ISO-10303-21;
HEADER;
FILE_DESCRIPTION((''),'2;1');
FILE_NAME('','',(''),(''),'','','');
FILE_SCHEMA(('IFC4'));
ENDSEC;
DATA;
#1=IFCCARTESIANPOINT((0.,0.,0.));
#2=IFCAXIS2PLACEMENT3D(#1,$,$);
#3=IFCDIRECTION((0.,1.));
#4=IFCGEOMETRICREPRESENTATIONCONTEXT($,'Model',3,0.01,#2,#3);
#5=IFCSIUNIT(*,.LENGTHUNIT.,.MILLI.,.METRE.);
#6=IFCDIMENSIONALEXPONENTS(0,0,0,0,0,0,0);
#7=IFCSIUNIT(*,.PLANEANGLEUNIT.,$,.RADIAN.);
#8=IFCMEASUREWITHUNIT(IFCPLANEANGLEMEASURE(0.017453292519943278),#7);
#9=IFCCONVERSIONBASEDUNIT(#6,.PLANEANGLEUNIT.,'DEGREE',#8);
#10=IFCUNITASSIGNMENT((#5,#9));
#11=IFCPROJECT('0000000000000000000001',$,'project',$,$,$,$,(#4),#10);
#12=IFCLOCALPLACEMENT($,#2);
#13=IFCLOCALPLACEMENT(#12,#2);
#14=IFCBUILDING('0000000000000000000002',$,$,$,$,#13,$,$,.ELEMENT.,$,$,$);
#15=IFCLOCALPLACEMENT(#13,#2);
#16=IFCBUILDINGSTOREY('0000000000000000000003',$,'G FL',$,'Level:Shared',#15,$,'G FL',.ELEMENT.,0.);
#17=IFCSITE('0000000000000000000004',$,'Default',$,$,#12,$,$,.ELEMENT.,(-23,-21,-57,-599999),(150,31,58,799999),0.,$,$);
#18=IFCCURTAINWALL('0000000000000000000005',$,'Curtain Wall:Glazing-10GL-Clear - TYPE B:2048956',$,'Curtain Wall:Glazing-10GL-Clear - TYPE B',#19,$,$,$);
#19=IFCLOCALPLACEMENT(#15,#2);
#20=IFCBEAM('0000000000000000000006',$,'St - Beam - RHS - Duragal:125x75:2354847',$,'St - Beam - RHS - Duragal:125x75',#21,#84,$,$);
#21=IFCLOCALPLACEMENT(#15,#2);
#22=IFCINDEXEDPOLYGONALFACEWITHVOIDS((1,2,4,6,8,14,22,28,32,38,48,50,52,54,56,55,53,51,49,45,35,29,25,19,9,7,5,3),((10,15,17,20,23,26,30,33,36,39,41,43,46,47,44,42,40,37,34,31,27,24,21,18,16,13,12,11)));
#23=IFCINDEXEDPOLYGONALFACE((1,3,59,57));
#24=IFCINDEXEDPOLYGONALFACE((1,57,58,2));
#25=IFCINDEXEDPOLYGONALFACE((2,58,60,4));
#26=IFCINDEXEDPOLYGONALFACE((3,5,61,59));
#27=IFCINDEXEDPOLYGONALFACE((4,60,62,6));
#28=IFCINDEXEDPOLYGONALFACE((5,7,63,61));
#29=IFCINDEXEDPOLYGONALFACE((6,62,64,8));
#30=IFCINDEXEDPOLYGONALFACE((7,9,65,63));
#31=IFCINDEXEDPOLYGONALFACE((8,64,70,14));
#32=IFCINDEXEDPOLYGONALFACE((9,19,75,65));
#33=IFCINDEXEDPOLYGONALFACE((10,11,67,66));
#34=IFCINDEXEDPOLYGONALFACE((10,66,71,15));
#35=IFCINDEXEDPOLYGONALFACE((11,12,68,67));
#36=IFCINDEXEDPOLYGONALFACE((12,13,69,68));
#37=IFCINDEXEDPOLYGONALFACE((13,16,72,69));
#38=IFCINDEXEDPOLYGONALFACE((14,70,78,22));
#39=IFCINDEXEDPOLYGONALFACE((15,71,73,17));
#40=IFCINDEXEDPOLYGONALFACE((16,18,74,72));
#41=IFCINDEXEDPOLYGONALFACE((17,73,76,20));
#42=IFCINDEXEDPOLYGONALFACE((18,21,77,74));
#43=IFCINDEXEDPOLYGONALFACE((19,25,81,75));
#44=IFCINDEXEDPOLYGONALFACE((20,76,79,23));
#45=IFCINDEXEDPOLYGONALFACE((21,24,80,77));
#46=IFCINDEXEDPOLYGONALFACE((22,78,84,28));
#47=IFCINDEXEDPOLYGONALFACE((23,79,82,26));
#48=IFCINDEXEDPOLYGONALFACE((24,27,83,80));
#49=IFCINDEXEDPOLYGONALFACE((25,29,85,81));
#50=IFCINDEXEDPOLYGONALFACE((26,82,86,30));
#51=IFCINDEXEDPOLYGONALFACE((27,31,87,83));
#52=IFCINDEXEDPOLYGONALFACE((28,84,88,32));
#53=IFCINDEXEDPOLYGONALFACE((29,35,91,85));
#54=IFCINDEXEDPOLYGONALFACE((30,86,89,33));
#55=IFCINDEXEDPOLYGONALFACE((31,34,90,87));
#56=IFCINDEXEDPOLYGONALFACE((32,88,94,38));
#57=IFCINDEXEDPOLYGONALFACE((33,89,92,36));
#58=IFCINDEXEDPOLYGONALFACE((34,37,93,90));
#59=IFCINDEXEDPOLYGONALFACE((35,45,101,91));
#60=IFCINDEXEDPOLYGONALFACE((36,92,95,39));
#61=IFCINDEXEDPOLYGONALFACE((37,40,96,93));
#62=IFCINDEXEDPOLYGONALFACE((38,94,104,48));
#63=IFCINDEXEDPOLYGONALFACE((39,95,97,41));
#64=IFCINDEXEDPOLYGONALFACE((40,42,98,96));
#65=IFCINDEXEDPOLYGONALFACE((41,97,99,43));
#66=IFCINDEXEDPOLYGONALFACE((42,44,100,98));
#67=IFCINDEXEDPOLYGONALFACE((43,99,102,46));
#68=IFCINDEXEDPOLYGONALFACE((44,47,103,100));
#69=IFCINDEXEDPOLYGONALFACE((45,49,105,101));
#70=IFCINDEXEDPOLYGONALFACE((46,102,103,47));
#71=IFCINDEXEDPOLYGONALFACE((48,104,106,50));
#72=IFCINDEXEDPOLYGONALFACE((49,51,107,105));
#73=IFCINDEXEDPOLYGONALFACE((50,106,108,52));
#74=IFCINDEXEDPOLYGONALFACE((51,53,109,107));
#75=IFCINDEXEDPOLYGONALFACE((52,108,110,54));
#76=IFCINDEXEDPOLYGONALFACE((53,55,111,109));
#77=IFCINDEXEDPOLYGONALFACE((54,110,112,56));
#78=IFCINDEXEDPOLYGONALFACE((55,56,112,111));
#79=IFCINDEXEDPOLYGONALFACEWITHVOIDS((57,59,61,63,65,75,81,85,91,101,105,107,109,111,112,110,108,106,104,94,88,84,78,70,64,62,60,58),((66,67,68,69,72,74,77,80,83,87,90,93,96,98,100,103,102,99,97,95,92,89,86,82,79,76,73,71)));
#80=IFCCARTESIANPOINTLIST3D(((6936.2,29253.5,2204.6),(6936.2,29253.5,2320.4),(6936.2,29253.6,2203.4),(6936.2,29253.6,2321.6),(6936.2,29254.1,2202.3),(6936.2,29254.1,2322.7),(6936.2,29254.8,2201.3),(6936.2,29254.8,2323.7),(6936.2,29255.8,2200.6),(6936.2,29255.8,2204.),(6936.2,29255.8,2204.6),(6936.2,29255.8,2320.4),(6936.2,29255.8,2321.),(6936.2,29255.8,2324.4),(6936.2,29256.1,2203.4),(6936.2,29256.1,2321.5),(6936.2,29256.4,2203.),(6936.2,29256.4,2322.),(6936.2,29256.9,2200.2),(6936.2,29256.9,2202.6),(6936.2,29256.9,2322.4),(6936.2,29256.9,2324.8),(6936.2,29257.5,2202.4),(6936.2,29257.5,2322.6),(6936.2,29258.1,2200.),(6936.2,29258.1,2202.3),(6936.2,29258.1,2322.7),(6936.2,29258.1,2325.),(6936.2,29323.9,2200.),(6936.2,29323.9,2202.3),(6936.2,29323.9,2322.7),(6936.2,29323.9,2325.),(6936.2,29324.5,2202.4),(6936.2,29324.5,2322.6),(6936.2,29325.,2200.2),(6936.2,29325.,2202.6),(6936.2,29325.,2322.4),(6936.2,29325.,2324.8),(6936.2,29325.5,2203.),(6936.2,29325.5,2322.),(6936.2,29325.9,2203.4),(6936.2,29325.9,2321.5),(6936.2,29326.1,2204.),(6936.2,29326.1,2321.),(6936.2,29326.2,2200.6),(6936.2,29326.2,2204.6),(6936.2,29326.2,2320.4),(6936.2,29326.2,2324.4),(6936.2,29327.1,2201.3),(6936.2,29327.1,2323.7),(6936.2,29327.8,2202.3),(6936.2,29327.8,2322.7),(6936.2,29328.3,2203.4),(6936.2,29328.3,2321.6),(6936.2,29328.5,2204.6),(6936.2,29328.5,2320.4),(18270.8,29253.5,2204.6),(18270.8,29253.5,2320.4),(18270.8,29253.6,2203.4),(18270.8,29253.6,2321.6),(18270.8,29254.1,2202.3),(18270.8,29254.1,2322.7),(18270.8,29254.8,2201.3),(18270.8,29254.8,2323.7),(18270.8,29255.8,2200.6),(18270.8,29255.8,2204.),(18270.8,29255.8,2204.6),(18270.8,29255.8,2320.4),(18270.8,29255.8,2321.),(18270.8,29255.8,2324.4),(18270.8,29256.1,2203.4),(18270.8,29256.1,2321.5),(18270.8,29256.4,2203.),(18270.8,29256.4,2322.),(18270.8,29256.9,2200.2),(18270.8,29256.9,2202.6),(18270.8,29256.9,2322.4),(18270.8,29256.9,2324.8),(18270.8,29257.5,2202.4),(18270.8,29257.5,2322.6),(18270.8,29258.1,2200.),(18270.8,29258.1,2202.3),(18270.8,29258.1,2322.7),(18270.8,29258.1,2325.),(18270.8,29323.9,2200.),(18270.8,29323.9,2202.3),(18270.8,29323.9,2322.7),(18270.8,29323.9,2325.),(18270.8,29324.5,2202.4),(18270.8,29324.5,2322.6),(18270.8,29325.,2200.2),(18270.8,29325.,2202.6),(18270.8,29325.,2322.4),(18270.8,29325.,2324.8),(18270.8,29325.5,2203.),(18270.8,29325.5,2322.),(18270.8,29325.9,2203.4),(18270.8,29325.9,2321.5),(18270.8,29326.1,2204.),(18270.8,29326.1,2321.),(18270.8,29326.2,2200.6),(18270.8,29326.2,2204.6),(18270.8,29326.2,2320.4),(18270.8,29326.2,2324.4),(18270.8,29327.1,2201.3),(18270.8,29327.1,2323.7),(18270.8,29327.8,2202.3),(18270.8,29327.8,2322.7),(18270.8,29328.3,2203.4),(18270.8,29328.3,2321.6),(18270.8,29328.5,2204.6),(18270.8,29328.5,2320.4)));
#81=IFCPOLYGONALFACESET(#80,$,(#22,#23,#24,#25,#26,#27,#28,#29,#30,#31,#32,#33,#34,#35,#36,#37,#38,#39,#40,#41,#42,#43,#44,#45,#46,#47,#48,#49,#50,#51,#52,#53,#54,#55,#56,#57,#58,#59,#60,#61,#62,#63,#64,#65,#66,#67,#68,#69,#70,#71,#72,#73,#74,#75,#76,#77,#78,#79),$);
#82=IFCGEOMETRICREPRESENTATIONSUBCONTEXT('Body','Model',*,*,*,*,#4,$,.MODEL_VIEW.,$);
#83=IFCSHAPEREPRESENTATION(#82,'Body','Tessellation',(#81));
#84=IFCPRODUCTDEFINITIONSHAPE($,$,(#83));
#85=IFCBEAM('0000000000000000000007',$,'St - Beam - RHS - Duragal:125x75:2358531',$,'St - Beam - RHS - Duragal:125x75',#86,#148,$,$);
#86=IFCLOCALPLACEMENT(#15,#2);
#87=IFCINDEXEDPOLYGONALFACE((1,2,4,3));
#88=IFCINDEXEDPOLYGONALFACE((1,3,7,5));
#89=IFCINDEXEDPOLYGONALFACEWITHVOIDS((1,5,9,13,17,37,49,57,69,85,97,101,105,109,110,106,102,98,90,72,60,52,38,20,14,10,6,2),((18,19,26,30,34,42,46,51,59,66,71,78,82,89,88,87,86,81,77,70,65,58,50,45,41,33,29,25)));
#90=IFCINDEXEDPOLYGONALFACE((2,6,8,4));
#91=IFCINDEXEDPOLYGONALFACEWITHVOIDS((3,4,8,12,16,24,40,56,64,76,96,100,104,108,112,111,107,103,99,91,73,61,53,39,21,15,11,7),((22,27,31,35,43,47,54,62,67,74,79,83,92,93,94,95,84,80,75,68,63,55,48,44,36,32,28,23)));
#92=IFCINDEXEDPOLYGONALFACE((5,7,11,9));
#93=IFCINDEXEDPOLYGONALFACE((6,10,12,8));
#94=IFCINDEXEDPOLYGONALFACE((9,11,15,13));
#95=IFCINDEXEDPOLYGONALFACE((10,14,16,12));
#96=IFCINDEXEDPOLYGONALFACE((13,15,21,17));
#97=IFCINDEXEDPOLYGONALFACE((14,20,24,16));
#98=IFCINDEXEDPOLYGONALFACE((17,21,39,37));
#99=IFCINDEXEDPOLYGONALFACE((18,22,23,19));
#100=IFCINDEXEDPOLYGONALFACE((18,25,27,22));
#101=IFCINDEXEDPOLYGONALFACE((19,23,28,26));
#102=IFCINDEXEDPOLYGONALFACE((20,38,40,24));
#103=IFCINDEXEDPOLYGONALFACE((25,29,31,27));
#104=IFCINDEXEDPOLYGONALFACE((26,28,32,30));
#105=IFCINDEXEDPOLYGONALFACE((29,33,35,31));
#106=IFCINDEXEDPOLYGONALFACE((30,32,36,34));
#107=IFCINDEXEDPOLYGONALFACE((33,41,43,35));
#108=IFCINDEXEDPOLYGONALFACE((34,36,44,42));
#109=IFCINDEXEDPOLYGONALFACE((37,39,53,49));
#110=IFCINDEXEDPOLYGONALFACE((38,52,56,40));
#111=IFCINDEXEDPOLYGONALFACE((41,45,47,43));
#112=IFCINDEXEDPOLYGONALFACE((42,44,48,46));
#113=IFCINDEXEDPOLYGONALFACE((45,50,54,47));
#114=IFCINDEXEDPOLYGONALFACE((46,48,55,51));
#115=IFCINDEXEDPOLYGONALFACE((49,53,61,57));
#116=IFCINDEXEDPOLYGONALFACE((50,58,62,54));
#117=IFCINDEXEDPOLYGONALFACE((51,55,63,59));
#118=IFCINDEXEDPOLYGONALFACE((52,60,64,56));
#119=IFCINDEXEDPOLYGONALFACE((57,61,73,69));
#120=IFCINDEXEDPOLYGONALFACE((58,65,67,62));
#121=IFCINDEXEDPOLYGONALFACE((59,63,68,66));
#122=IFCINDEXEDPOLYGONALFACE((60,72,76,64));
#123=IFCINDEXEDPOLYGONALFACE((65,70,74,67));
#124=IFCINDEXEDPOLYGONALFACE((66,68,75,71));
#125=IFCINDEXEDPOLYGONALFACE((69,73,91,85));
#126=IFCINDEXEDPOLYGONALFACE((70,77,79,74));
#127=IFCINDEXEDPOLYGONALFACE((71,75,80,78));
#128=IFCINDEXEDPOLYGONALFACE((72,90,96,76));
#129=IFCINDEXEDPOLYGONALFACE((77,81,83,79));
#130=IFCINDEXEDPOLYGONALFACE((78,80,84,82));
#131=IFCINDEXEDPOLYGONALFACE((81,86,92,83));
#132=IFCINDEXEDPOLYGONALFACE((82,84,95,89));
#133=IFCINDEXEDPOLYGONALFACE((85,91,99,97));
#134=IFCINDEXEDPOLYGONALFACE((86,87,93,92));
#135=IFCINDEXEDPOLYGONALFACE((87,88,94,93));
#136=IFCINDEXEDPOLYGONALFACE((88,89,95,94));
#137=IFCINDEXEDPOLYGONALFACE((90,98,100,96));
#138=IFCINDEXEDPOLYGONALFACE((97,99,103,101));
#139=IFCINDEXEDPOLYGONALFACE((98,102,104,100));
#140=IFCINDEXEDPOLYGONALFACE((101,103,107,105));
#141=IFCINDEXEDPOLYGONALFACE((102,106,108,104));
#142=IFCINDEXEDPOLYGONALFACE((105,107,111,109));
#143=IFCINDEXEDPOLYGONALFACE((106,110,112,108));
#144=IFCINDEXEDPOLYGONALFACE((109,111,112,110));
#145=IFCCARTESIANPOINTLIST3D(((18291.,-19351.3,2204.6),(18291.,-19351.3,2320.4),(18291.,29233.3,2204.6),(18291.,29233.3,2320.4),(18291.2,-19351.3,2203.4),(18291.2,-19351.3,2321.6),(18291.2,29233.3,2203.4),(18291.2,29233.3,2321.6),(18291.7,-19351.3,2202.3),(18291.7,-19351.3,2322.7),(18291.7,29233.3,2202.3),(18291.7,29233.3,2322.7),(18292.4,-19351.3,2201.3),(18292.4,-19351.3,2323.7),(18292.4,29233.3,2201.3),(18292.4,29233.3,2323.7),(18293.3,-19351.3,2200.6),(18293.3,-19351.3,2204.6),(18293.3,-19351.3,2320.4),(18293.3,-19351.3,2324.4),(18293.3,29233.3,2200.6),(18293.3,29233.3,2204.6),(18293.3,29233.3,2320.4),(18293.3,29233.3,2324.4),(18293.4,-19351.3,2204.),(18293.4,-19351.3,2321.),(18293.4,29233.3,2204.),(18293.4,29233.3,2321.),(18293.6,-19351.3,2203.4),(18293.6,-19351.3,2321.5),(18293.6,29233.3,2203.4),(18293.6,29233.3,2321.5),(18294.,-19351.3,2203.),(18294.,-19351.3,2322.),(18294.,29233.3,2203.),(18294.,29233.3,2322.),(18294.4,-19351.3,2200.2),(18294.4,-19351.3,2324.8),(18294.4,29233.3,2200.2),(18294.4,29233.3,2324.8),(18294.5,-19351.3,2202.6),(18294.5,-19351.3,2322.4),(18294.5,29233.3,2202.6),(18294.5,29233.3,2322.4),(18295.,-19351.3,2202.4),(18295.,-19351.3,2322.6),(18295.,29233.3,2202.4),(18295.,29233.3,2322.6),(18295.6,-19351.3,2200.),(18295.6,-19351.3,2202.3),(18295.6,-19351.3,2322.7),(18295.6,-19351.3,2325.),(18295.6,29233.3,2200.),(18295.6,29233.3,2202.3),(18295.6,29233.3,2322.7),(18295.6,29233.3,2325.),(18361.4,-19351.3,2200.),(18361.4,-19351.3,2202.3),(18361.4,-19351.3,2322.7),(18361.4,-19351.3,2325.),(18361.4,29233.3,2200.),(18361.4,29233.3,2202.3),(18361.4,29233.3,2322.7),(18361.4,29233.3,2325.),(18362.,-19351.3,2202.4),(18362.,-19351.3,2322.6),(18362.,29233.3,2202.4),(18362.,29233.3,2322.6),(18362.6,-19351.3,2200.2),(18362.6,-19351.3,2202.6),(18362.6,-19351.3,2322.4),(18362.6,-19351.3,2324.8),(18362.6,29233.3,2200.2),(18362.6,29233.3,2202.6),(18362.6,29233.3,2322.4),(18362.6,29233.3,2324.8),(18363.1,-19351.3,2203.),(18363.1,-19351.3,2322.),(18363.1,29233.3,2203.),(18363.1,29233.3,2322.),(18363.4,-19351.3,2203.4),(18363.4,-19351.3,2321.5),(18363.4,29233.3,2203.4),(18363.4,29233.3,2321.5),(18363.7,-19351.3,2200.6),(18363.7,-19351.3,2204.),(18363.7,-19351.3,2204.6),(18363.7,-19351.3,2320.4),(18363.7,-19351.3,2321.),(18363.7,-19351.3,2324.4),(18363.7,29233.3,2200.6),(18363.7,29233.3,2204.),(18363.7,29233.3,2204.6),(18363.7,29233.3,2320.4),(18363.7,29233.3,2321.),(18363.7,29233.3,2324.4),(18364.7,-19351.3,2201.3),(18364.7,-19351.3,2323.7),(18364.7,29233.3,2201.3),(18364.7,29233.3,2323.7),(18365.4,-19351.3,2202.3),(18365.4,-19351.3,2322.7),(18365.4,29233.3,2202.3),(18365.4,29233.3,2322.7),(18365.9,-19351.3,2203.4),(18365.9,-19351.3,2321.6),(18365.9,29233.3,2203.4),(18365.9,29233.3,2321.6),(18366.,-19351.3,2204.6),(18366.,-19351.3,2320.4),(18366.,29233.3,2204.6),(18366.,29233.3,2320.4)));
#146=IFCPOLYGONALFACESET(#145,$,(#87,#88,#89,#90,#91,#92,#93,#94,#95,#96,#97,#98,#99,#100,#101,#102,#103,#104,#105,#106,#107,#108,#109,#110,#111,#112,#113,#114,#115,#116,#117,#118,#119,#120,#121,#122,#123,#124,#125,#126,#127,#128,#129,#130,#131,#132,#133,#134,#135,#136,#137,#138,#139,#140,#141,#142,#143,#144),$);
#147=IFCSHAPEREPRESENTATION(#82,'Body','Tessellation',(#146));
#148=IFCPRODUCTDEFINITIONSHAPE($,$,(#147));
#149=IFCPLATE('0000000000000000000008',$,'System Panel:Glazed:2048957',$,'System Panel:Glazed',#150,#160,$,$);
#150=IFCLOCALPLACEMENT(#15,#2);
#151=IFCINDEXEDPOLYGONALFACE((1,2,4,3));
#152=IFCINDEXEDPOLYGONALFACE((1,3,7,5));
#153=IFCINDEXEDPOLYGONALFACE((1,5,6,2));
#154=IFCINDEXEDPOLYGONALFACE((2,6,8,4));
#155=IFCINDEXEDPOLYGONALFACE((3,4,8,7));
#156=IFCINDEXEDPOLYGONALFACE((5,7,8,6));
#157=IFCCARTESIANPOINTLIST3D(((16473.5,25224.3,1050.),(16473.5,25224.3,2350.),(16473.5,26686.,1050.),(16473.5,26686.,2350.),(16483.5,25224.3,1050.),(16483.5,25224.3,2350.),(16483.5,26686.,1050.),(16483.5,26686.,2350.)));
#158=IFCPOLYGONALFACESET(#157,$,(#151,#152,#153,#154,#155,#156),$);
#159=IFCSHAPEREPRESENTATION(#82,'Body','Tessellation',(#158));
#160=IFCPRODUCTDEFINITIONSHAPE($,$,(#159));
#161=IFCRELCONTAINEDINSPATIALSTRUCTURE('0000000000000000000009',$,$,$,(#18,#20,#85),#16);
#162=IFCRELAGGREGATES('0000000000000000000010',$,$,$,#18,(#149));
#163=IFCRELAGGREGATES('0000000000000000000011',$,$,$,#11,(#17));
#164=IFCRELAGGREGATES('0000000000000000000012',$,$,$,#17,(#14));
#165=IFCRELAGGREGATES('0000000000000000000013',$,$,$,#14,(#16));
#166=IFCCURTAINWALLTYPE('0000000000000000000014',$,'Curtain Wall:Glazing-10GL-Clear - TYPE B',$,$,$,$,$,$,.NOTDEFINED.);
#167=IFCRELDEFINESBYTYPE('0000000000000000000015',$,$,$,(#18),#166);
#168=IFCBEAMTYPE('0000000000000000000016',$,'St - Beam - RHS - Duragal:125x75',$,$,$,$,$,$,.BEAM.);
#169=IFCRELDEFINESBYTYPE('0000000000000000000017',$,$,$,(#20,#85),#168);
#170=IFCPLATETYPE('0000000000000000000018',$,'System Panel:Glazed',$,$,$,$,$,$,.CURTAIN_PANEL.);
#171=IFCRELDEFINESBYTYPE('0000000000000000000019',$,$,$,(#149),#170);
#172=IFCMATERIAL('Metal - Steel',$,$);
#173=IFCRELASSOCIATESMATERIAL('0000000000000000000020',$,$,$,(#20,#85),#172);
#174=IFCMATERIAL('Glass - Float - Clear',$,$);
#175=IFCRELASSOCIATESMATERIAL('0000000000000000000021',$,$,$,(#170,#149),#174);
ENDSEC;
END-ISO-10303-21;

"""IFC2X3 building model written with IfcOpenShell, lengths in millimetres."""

from ifc_helpers import new_model, entity, si_unit, converted_unit, direction, frame, frame_2d, origin, origin_2d_with_axis, place, context, subcontext, project, spatial, polyline, circle_curve, parameter, trimmed, segment, composite_curve, rectangle, outline, extrude, source, transform, mapped, material, type_object, type_shapes, element, aggregate, save


model = new_model("IFC2X3")

# Units and contexts
model_context = context("Model", 3, precision=0.01, world=origin(), true_north=direction((0.0, 1.0)))
body_context = subcontext(model_context, "Body", "Model", "MODEL_VIEW")
ifc_project = project(units=[si_unit("LENGTHUNIT", "METRE", prefix="MILLI"), converted_unit("PLANEANGLEUNIT", "DEGREE", entity("IfcPlaneAngleMeasure", 0.017453292519943278), si_unit("PLANEANGLEUNIT", "RADIAN"), dimensions=[0, 0, 0, 0, 0, 0, 0])], contexts=[model_context])

# Site, building, storey
site_placement = place(None, origin())
site = spatial("IfcSite", under=ifc_project, at=site_placement, Name="Default", CompositionType="ELEMENT", RefLatitude=(-23, -21, -57, -599999), RefLongitude=(150, 31, 58, 799999), RefElevation=0.0)
building_placement = place(site_placement, origin())
building = spatial("IfcBuilding", under=site, at=building_placement, CompositionType="ELEMENT")
storey_placement = place(building_placement, origin())
storey = spatial("IfcBuildingStorey", under=building, at=storey_placement, Name="G FL", ObjectType="Level:Shared", LongName="G FL", CompositionType="ELEMENT", Elevation=0.0)

# Shared definitions
curtain_wall_type = type_object("IfcCurtainWallType", Name="Curtain Wall:Glazing-10GL-Clear - TYPE B", PredefinedType="NOTDEFINED")

# Curtain wall
curtain_wall_1_placement = place(storey_placement, origin())
curtain_wall_1 = element("IfcCurtainWall", 1, at=curtain_wall_1_placement, inside=storey, type_object=curtain_wall_type, Name="Curtain Wall:Glazing-10GL-Clear - TYPE B:2048956", ObjectType="Curtain Wall:Glazing-10GL-Clear - TYPE B")

# Beams
ifc_material_1 = material(Name="Metal - Steel")
beam_type_1 = type_object("IfcBeamType", Name="St - Beam - RHS - Duragal:125x75", PredefinedType="BEAM")
beam_1_placement = place(storey_placement, frame((18328.5, 29291.0, 2325.0), z_axis=(0.0, 0.0, 1.0), x_axis=(-1.0, 0.0, 0.0)))
element("IfcBeam", 2, at=beam_1_placement, inside=storey, type_object=beam_type_1, material=ifc_material_1, Name="St - Beam - RHS - Duragal:125x75:2354847", ObjectType="St - Beam - RHS - Duragal:125x75", context=body_context, shape_type="SweptSolid", body=[
    extrude(outline(composite_curve([segment(polyline([(-32.9, -62.5), (32.9, -62.5)]), True, "CONTINUOUS"), segment(trimmed(circle_curve(frame_2d((32.9, -57.9), x_axis=(1.0, 0.0)), 4.6), [parameter(270.0)], [parameter(0.0)], True, "PARAMETER"), True, "CONTINUOUS"), segment(polyline([(37.5, -57.9), (37.5, 57.9)]), True, "CONTINUOUS"), segment(trimmed(circle_curve(frame_2d((32.9, 57.9), x_axis=(1.0, 0.0)), 4.6), [parameter(0.0)], [parameter(90.0)], True, "PARAMETER"), True, "CONTINUOUS"), segment(polyline([(32.9, 62.5), (-32.9, 62.5)]), True, "CONTINUOUS"), segment(trimmed(circle_curve(frame_2d((-32.9, 57.9), x_axis=(1.0, 0.0)), 4.6), [parameter(90.0)], [parameter(180.0)], True, "PARAMETER"), True, "CONTINUOUS"), segment(polyline([(-37.5, 57.9), (-37.5, -57.9)]), True, "CONTINUOUS"), segment(trimmed(circle_curve(frame_2d((-32.9, -57.9), x_axis=(1.0, 0.0)), 4.6), [parameter(180.0)], [parameter(270.0)], True, "PARAMETER"), True, "CONTINUOUS")], self_intersect=False), holes=[composite_curve([segment(polyline([(35.2, 57.9), (35.2, -57.9)]), True, "CONTINUOUS"), segment(trimmed(circle_curve(frame_2d((32.9, -57.9), x_axis=(1.0, 0.0)), 2.3), [parameter(270.0)], [parameter(0.0)], True, "PARAMETER"), False, "CONTINUOUS"), segment(polyline([(32.9, -60.2), (-32.9, -60.2)]), True, "CONTINUOUS"), segment(trimmed(circle_curve(frame_2d((-32.9, -57.9), x_axis=(1.0, 0.0)), 2.3), [parameter(180.0)], [parameter(270.0)], True, "PARAMETER"), False, "CONTINUOUS"), segment(polyline([(-35.2, -57.9), (-35.2, 57.9)]), True, "CONTINUOUS"), segment(trimmed(circle_curve(frame_2d((-32.9, 57.9), x_axis=(1.0, 0.0)), 2.3), [parameter(90.0)], [parameter(180.0)], True, "PARAMETER"), False, "CONTINUOUS"), segment(polyline([(-32.9, 60.2), (32.9, 60.2)]), True, "CONTINUOUS"), segment(trimmed(circle_curve(frame_2d((32.9, 57.9), x_axis=(1.0, 0.0)), 2.3), [parameter(0.0)], [parameter(90.0)], True, "PARAMETER"), False, "CONTINUOUS")], self_intersect=False)]), frame((57.7, 0.0, -62.5), z_axis=(1.0, 0.0, 0.0), x_axis=(0.0, -1.0, 0.0)), (0.0, 0.0, 1.0), 11334.6),
])
beam_2_placement = place(storey_placement, frame((18328.5, 29291.0, 2325.0), z_axis=(0.0, 0.0, 1.0), x_axis=(0.0, -1.0, 0.0)))
element("IfcBeam", 3, at=beam_2_placement, inside=storey, type_object=beam_type_1, material=ifc_material_1, Name="St - Beam - RHS - Duragal:125x75:2358531", ObjectType="St - Beam - RHS - Duragal:125x75", context=body_context, shape_type="SweptSolid", body=[
    extrude(outline(composite_curve([segment(trimmed(circle_curve(frame_2d((-32.9, 57.9), x_axis=(1.0, 0.0)), 4.6), [parameter(90.0)], [parameter(180.0)], True, "PARAMETER"), True, "CONTINUOUS"), segment(polyline([(-37.5, 57.9), (-37.5, -57.9)]), True, "CONTINUOUS"), segment(trimmed(circle_curve(frame_2d((-32.9, -57.9), x_axis=(1.0, 0.0)), 4.6), [parameter(180.0)], [parameter(270.0)], True, "PARAMETER"), True, "CONTINUOUS"), segment(polyline([(-32.9, -62.5), (32.9, -62.5)]), True, "CONTINUOUS"), segment(trimmed(circle_curve(frame_2d((32.9, -57.9), x_axis=(1.0, 0.0)), 4.6), [parameter(270.0)], [parameter(360.0)], True, "PARAMETER"), True, "CONTINUOUS"), segment(polyline([(37.5, -57.9), (37.5, 57.9)]), True, "CONTINUOUS"), segment(trimmed(circle_curve(frame_2d((32.9, 57.9), x_axis=(1.0, 0.0)), 4.6), [parameter(0.0)], [parameter(90.0)], True, "PARAMETER"), True, "CONTINUOUS"), segment(polyline([(32.9, 62.5), (-32.9, 62.5)]), True, "CONTINUOUS")], self_intersect=False), holes=[composite_curve([segment(trimmed(circle_curve(frame_2d((32.9, -57.9), x_axis=(1.0, 0.0)), 2.3), [parameter(270.0)], [parameter(360.0)], True, "PARAMETER"), False, "CONTINUOUS"), segment(polyline([(32.9, -60.2), (-32.9, -60.2)]), True, "CONTINUOUS"), segment(trimmed(circle_curve(frame_2d((-32.9, -57.9), x_axis=(1.0, 0.0)), 2.3), [parameter(180.0)], [parameter(270.0)], True, "PARAMETER"), False, "CONTINUOUS"), segment(polyline([(-35.2, -57.9), (-35.2, 57.9)]), True, "CONTINUOUS"), segment(trimmed(circle_curve(frame_2d((-32.9, 57.9), x_axis=(1.0, 0.0)), 2.3), [parameter(90.0)], [parameter(180.0)], True, "PARAMETER"), False, "CONTINUOUS"), segment(polyline([(-32.9, 60.2), (32.9, 60.2)]), True, "CONTINUOUS"), segment(trimmed(circle_curve(frame_2d((32.9, 57.9), x_axis=(1.0, 0.0)), 2.3), [parameter(0.0)], [parameter(90.0)], True, "PARAMETER"), False, "CONTINUOUS"), segment(polyline([(35.2, 57.9), (35.2, -57.9)]), True, "CONTINUOUS")], self_intersect=False)]), frame((57.7, 0.0, -62.5), z_axis=(1.0, 0.0, 0.0), x_axis=(0.0, 1.0, 0.0)), (0.0, 0.0, 1.0), 48584.6),
])

# Plate
ifc_material_2 = material(Name="Glass - Float - Clear")
plate_type = type_object("IfcPlateType", Name="System Panel:Glazed", PredefinedType="CURTAIN_PANEL", material=ifc_material_2)
shared_shape_1 = source(origin(), body_context, "Body", "SweptSolid", [
    extrude(rectangle(XDim=10.0, YDim=1461.7, at=origin_2d_with_axis()), frame((0.0, 0.0, 0.0), z_axis=(0.0, 0.0, 1.0), x_axis=(0.0, 1.0, 0.0)), (0.0, 0.0, 1.0), 1300.0),
])
type_shapes(plate_type, [shared_shape_1])
plate_1_placement = place(curtain_wall_1_placement, frame((16478.5, 25955.1, 1050.0), z_axis=(0.0, 0.0, 1.0), x_axis=(0.0, -1.0, 0.0)))
plate_1 = element("IfcPlate", 4, at=plate_1_placement, type_object=plate_type, material=ifc_material_2, Name="System Panel:Glazed:2048957", ObjectType="System Panel:Glazed", context=body_context, shape_type="MappedRepresentation", body=[
    mapped(shared_shape_1, transform((0.0, 0.0, 0.0), scale=1.0)),
])
aggregate(curtain_wall_1, [plate_1])

save(model, "model.ifc")
